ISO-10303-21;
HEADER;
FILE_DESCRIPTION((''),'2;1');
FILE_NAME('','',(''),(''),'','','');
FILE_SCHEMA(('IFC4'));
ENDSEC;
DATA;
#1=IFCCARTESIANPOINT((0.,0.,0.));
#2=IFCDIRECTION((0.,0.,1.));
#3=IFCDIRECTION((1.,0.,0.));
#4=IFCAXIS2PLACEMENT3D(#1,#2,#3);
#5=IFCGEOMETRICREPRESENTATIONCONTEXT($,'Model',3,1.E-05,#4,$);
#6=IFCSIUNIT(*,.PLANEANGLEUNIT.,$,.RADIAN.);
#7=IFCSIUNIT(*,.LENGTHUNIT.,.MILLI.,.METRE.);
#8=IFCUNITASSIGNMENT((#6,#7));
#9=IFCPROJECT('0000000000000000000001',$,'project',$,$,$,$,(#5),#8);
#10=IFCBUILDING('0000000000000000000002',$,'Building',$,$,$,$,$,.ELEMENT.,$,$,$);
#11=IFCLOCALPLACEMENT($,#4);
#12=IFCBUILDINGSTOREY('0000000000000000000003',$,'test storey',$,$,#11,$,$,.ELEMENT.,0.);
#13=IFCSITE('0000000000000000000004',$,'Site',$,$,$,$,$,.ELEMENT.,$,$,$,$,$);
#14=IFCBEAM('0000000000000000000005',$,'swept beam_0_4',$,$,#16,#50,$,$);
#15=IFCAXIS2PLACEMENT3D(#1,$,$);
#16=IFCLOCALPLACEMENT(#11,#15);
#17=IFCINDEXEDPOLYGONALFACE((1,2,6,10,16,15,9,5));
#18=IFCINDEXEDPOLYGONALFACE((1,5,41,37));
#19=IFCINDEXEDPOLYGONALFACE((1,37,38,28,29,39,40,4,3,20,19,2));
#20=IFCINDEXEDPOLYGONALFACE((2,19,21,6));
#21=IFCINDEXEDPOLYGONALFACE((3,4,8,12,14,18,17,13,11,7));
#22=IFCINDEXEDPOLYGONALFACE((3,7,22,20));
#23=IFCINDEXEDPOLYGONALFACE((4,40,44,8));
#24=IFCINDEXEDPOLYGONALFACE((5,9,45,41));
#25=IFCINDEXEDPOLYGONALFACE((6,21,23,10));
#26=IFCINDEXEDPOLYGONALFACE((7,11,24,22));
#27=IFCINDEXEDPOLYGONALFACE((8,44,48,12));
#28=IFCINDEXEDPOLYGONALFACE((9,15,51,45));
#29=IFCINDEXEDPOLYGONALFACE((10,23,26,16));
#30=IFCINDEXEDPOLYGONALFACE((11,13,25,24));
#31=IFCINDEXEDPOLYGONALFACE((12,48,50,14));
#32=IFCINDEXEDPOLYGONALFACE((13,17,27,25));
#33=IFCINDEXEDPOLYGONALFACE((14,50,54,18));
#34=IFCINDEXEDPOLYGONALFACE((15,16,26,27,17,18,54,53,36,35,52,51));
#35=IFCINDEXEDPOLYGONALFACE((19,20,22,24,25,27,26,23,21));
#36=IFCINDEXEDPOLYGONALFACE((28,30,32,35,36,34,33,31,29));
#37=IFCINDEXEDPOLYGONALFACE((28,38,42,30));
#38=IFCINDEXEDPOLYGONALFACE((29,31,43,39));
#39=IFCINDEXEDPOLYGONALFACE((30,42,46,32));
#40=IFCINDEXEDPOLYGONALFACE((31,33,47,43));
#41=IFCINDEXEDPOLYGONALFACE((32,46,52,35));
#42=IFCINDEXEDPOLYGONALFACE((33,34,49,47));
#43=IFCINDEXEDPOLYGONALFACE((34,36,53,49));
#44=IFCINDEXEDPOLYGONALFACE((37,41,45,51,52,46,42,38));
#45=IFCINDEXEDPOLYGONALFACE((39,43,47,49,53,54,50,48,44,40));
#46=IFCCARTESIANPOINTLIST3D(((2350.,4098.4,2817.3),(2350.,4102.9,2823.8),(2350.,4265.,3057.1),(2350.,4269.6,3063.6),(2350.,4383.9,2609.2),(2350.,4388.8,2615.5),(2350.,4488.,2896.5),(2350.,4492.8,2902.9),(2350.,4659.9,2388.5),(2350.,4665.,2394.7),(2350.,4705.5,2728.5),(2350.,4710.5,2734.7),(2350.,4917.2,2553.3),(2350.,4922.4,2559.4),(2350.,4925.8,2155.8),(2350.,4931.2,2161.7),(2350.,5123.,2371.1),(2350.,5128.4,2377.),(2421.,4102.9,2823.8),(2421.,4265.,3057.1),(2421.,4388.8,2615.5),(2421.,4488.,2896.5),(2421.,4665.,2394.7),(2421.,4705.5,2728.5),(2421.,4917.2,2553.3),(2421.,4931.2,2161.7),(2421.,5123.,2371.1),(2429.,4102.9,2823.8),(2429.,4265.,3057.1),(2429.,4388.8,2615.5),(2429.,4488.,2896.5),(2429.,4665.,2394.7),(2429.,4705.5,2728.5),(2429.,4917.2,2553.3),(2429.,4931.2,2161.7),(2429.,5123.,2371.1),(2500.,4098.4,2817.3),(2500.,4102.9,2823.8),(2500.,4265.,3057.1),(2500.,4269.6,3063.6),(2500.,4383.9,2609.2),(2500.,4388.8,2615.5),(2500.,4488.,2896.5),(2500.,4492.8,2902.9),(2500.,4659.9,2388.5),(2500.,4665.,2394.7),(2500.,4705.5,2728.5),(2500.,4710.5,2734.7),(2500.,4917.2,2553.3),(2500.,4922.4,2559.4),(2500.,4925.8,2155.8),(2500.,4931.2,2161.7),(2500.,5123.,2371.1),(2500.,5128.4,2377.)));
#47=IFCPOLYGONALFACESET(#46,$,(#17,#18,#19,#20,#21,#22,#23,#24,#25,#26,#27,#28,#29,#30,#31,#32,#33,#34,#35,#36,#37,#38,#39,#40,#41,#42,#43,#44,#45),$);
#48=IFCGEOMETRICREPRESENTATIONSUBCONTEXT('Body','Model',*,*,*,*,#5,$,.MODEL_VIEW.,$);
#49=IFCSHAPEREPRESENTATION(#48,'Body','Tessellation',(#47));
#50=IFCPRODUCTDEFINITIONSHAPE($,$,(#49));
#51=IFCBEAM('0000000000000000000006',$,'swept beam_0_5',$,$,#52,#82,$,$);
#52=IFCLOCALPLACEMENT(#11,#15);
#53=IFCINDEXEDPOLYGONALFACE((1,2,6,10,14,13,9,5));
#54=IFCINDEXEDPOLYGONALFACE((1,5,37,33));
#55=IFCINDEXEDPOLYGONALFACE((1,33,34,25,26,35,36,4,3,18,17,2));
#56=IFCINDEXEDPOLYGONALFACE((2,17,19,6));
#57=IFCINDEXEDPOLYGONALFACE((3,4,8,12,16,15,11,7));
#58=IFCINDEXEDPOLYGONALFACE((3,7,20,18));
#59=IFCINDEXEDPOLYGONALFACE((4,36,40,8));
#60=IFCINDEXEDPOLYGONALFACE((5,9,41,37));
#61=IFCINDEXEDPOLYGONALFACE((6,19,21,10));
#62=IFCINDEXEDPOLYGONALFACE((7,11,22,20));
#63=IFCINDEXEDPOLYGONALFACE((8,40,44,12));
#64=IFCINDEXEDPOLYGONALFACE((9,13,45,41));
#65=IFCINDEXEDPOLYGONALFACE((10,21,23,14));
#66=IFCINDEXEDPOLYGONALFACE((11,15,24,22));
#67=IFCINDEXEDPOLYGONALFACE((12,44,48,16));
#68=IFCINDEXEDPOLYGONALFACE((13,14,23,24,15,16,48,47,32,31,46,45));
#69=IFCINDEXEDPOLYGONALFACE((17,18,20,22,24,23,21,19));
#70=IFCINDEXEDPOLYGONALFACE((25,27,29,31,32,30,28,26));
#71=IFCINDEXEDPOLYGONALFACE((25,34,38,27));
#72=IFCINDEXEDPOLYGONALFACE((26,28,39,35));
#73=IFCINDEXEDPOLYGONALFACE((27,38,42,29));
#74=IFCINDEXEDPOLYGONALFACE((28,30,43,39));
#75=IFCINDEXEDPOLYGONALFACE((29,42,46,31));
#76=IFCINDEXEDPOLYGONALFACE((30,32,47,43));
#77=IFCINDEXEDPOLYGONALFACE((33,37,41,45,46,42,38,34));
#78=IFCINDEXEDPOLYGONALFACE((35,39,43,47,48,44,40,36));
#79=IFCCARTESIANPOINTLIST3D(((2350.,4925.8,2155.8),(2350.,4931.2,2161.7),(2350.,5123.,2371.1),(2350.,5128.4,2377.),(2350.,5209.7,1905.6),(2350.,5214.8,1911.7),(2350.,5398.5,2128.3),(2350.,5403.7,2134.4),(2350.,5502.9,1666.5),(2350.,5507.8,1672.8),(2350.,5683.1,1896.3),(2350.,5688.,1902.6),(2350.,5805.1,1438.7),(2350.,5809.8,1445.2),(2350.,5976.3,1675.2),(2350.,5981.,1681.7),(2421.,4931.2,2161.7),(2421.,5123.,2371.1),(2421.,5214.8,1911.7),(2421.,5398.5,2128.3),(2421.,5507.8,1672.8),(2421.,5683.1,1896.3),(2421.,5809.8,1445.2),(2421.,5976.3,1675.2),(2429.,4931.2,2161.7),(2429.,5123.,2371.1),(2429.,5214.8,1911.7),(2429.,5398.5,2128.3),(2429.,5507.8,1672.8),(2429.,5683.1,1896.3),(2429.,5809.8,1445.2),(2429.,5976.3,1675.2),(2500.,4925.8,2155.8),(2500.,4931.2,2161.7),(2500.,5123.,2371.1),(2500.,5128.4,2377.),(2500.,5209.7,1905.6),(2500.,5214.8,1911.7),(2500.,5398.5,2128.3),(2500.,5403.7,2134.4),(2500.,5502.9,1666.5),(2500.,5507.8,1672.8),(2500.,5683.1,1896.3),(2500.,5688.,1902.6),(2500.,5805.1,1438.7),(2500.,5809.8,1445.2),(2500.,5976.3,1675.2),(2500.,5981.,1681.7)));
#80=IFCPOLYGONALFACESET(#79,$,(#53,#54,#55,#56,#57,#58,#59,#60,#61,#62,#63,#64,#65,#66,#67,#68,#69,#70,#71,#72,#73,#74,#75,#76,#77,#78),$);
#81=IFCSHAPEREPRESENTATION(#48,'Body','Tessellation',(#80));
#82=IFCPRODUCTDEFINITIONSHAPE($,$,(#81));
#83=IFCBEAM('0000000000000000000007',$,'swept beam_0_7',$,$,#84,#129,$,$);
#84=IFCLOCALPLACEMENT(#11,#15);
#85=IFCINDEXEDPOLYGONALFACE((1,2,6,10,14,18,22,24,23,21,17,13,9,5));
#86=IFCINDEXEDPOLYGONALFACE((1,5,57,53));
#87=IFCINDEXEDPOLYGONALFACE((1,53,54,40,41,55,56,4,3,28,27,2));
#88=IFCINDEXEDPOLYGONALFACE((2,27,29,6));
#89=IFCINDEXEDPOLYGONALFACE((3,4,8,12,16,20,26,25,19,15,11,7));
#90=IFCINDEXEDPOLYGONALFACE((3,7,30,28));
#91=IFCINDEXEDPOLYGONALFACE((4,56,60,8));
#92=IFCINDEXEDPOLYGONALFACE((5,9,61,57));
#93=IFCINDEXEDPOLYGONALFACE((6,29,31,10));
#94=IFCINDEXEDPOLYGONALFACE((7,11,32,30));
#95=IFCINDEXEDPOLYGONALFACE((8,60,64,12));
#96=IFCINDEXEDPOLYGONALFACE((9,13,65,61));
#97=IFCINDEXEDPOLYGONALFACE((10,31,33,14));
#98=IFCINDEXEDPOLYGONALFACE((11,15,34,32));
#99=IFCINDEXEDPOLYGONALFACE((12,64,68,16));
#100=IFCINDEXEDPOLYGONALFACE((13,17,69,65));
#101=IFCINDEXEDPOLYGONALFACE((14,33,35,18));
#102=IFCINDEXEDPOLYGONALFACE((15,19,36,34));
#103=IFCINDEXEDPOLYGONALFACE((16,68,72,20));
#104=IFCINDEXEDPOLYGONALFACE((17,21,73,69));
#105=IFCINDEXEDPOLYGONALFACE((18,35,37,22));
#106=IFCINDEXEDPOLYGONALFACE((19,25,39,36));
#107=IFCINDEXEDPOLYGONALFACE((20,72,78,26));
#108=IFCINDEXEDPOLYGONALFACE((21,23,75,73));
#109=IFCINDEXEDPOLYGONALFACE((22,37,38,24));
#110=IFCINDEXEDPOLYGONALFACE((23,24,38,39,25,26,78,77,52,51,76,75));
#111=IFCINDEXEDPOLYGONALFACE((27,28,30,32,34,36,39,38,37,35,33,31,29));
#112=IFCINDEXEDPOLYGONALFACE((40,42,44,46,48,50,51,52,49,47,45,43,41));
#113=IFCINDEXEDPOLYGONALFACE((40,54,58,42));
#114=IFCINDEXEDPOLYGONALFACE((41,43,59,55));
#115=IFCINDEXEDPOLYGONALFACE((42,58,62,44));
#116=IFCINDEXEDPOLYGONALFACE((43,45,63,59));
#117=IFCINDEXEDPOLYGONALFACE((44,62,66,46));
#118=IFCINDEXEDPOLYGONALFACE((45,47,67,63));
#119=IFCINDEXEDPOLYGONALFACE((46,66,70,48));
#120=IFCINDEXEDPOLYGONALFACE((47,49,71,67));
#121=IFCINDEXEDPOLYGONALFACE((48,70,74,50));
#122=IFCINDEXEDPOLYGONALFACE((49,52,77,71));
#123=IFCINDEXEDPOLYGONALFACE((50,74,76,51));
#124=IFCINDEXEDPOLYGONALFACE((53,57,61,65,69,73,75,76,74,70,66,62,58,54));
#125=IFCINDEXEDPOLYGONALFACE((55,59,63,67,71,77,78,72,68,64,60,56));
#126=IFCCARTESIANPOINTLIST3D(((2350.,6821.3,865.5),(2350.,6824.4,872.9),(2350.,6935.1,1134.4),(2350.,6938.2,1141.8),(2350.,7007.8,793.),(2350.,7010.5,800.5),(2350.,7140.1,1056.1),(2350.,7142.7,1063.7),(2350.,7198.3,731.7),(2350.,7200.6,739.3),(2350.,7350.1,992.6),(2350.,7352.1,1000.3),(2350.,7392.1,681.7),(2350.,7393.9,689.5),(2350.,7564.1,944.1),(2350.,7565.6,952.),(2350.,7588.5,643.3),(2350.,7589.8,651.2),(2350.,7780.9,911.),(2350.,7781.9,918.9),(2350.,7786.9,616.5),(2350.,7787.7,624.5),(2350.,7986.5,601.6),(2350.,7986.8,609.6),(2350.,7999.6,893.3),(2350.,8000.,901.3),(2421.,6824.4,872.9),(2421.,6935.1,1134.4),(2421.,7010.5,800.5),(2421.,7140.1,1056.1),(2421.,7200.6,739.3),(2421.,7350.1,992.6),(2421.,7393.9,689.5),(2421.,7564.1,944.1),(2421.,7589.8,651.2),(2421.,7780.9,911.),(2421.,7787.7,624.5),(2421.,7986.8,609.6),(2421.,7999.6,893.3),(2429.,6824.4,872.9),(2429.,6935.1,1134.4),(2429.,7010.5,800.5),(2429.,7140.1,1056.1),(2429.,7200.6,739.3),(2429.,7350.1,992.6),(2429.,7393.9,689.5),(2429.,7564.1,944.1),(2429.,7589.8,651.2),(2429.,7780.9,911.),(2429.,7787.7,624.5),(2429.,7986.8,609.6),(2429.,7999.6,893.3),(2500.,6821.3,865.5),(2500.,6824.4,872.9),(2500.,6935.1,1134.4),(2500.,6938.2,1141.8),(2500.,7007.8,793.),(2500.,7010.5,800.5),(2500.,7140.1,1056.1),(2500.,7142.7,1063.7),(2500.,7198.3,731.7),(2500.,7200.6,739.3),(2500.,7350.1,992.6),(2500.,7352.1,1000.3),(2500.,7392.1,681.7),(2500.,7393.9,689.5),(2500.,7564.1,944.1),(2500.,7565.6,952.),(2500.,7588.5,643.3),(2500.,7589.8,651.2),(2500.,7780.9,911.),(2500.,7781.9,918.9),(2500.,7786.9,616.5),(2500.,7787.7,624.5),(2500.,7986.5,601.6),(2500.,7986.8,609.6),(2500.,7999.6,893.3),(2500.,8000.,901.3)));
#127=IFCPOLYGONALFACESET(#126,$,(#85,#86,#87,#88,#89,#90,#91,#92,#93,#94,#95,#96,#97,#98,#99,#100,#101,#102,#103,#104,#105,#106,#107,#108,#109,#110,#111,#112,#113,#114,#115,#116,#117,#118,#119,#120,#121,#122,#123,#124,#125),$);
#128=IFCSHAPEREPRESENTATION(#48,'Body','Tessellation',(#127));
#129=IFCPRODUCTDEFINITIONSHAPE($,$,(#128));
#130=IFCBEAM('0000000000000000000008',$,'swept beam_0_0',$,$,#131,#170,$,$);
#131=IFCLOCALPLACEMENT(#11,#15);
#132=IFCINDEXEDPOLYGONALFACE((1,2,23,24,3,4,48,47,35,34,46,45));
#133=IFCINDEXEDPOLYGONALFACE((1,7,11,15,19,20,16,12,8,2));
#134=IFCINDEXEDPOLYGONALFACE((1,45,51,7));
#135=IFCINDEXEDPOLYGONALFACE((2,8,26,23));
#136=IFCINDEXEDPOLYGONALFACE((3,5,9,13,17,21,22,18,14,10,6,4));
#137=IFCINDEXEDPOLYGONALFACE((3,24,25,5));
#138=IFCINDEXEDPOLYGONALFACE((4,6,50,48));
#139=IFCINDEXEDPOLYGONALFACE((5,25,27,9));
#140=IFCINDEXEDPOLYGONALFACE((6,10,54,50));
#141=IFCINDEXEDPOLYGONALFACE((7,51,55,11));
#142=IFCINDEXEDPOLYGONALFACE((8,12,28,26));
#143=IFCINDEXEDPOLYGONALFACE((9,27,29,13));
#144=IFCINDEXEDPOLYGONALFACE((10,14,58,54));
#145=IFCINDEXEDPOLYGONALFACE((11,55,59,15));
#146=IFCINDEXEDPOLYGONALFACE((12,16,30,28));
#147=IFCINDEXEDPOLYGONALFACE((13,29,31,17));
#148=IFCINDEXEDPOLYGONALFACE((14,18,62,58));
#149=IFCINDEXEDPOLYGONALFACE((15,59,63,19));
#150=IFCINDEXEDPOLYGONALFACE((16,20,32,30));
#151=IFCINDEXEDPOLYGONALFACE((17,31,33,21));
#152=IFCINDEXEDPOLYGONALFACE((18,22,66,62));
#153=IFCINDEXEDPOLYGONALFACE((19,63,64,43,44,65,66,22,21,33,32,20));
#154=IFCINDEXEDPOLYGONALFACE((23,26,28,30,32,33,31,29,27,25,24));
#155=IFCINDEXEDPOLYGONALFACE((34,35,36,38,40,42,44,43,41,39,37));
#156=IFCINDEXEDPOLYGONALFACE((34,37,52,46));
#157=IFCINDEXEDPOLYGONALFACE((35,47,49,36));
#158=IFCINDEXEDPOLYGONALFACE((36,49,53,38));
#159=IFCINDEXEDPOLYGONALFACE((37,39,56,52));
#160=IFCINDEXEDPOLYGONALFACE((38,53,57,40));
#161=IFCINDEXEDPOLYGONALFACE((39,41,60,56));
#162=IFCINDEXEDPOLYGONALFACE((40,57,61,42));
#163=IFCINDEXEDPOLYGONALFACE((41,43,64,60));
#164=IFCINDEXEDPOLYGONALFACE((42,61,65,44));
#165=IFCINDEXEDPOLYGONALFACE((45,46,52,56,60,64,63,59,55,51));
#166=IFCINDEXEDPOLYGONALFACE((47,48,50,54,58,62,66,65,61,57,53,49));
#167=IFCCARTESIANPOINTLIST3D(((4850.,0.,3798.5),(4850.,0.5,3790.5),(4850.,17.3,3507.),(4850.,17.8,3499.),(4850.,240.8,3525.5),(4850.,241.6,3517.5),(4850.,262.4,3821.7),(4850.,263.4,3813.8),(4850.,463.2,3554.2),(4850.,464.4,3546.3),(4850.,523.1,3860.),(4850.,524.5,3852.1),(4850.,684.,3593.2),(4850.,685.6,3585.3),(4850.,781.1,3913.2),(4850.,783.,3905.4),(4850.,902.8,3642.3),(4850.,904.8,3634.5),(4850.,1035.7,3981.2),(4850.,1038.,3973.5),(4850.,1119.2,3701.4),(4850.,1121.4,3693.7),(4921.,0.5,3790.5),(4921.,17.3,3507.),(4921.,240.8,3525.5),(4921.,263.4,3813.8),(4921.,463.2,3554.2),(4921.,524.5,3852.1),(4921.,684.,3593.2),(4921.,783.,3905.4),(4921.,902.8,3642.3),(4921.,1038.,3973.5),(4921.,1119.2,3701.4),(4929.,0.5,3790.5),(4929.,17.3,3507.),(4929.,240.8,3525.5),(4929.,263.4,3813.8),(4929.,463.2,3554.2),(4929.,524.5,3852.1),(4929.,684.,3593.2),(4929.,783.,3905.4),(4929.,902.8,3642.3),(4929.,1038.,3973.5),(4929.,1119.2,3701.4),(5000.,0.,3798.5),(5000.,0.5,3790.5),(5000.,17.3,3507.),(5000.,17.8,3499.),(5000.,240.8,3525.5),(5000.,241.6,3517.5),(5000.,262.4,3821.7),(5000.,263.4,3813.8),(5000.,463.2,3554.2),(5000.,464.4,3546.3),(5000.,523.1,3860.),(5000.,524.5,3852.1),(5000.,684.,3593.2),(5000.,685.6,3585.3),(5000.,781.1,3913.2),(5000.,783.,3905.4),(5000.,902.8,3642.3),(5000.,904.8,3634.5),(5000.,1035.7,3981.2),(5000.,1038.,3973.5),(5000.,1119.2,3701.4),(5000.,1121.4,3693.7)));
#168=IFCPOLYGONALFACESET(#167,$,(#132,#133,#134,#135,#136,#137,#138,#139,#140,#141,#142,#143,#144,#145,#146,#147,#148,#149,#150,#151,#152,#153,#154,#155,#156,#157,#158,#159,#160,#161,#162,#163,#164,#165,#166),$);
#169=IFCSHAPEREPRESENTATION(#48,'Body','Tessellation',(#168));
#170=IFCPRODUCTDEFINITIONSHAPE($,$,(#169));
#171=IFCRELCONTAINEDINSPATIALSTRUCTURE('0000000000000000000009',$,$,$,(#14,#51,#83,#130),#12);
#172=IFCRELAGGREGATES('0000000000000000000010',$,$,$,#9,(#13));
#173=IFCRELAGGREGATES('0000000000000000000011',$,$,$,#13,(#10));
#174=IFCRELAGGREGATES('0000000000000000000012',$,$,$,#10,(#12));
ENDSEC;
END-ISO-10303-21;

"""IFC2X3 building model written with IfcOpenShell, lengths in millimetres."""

from ifc_helpers import new_model, entity, si_unit, origin_with_axes, place, context, subcontext, project, spatial, element, save


model = new_model("IFC2X3")

# Units and contexts
model_context = context("Model", 3, precision=1e-05, world=origin_with_axes())
body_context = subcontext(model_context, "Body", "Model", "MODEL_VIEW")
ifc_project = project(units=[si_unit("PLANEANGLEUNIT", "RADIAN"), si_unit("LENGTHUNIT", "METRE", prefix="MILLI")], contexts=[model_context])

# Site, building, storey
site = spatial("IfcSite", under=ifc_project, Name="Site", CompositionType="ELEMENT")
building = spatial("IfcBuilding", under=site, Name="Building", CompositionType="ELEMENT")
storey_placement = place(None, origin_with_axes())
storey = spatial("IfcBuildingStorey", under=building, at=storey_placement, Name="test storey", CompositionType="ELEMENT", Elevation=0.0)

# Beams
beam_1_placement = place(storey_placement, origin_with_axes())
element("IfcBeam", 1, at=beam_1_placement, inside=storey, Name="swept beam_0_4", context=body_context, shape_type="SweptSolid", body=[
    entity("IfcRevolvedAreaSolid", entity("IfcArbitraryClosedProfileDef", "AREA", None, entity("IfcPolyline", [entity("IfcCartesianPoint", [-292.0, 0.0]), entity("IfcCartesianPoint", [-292.0, 71.0]), entity("IfcCartesianPoint", [-8.0, 71.0]), entity("IfcCartesianPoint", [-8.0, 0.0]), entity("IfcCartesianPoint", [0.0, 0.0]), entity("IfcCartesianPoint", [0.0, 150.0]), entity("IfcCartesianPoint", [-8.0, 150.0]), entity("IfcCartesianPoint", [-8.0, 79.0]), entity("IfcCartesianPoint", [-292.0, 79.0]), entity("IfcCartesianPoint", [-292.0, 150.0]), entity("IfcCartesianPoint", [-300.0, 150.0]), entity("IfcCartesianPoint", [-300.0, 0.0]), entity("IfcCartesianPoint", [-292.0, 0.0])])), entity("IfcAxis2Placement3D", entity("IfcCartesianPoint", [2500.0, 4269.6, 3063.6]), entity("IfcDirection", [0.0, -0.8212, 0.5707]), entity("IfcDirection", [0.0, 0.5707, 0.8212])), entity("IfcAxis1Placement", entity("IfcCartesianPoint", [-8200.7, 0.0, 0.0]), entity("IfcDirection", [0.0, 1.0, 0.0])), 0.13418),
])
beam_2_placement = place(storey_placement, origin_with_axes())
element("IfcBeam", 2, at=beam_2_placement, inside=storey, Name="swept beam_0_5", context=body_context, shape_type="SweptSolid", body=[
    entity("IfcRevolvedAreaSolid", entity("IfcArbitraryClosedProfileDef", "AREA", None, entity("IfcPolyline", [entity("IfcCartesianPoint", [292.0, 0.0]), entity("IfcCartesianPoint", [292.0, -71.0]), entity("IfcCartesianPoint", [8.0, -71.0]), entity("IfcCartesianPoint", [8.0, 0.0]), entity("IfcCartesianPoint", [0.0, 0.0]), entity("IfcCartesianPoint", [0.0, -150.0]), entity("IfcCartesianPoint", [8.0, -150.0]), entity("IfcCartesianPoint", [8.0, -79.0]), entity("IfcCartesianPoint", [292.0, -79.0]), entity("IfcCartesianPoint", [292.0, -150.0]), entity("IfcCartesianPoint", [300.0, -150.0]), entity("IfcCartesianPoint", [300.0, 0.0]), entity("IfcCartesianPoint", [292.0, 0.0])])), entity("IfcAxis2Placement3D", entity("IfcCartesianPoint", [2500.0, 5128.4, 2377.0]), entity("IfcDirection", [0.0, -0.7375, 0.6754]), entity("IfcDirection", [0.0, -0.6754, -0.7375])), entity("IfcAxis1Placement", entity("IfcCartesianPoint", [-9597.6, 0.0, 0.0]), entity("IfcDirection", [0.0, 1.0, 0.0])), 0.114697),
])
beam_3_placement = place(storey_placement, origin_with_axes())
element("IfcBeam", 3, at=beam_3_placement, inside=storey, Name="swept beam_0_7", context=body_context, shape_type="SweptSolid", body=[
    entity("IfcRevolvedAreaSolid", entity("IfcArbitraryClosedProfileDef", "AREA", None, entity("IfcPolyline", [entity("IfcCartesianPoint", [292.0, 0.0]), entity("IfcCartesianPoint", [292.0, -71.0]), entity("IfcCartesianPoint", [8.0, -71.0]), entity("IfcCartesianPoint", [8.0, 0.0]), entity("IfcCartesianPoint", [0.0, 0.0]), entity("IfcCartesianPoint", [0.0, -150.0]), entity("IfcCartesianPoint", [8.0, -150.0]), entity("IfcCartesianPoint", [8.0, -79.0]), entity("IfcCartesianPoint", [292.0, -79.0]), entity("IfcCartesianPoint", [292.0, -150.0]), entity("IfcCartesianPoint", [300.0, -150.0]), entity("IfcCartesianPoint", [300.0, 0.0]), entity("IfcCartesianPoint", [292.0, 0.0])])), entity("IfcAxis2Placement3D", entity("IfcCartesianPoint", [2500.0, 6938.2, 1141.8]), entity("IfcDirection", [0.0, -0.9209, 0.3897]), entity("IfcDirection", [0.0, -0.3897, -0.9209])), entity("IfcAxis1Placement", entity("IfcCartesianPoint", [-3081.4, 0.0, 0.0]), entity("IfcDirection", [0.0, 1.0, 0.0])), 0.355161),
])
beam_4_placement = place(storey_placement, origin_with_axes())
element("IfcBeam", 4, at=beam_4_placement, inside=storey, Name="swept beam_0_0", context=body_context, shape_type="SweptSolid", body=[
    entity("IfcRevolvedAreaSolid", entity("IfcArbitraryClosedProfileDef", "AREA", None, entity("IfcPolyline", [entity("IfcCartesianPoint", [292.0, 0.0]), entity("IfcCartesianPoint", [292.0, -71.0]), entity("IfcCartesianPoint", [8.0, -71.0]), entity("IfcCartesianPoint", [8.0, 0.0]), entity("IfcCartesianPoint", [0.0, 0.0]), entity("IfcCartesianPoint", [0.0, -150.0]), entity("IfcCartesianPoint", [8.0, -150.0]), entity("IfcCartesianPoint", [8.0, -79.0]), entity("IfcCartesianPoint", [292.0, -79.0]), entity("IfcCartesianPoint", [292.0, -150.0]), entity("IfcCartesianPoint", [300.0, -150.0]), entity("IfcCartesianPoint", [300.0, 0.0]), entity("IfcCartesianPoint", [292.0, 0.0])])), entity("IfcAxis2Placement3D", entity("IfcCartesianPoint", [5000.0, 0.0, 3798.5]), entity("IfcDirection", [0.0, -0.9982, -0.0593]), entity("IfcDirection", [0.0, 0.0593, -0.9982])), entity("IfcAxis1Placement", entity("IfcCartesianPoint", [-4571.7, 0.0, 0.0]), entity("IfcDirection", [0.0, 1.0, 0.0])), 0.230553),
])

save(model, "model.ifc")
